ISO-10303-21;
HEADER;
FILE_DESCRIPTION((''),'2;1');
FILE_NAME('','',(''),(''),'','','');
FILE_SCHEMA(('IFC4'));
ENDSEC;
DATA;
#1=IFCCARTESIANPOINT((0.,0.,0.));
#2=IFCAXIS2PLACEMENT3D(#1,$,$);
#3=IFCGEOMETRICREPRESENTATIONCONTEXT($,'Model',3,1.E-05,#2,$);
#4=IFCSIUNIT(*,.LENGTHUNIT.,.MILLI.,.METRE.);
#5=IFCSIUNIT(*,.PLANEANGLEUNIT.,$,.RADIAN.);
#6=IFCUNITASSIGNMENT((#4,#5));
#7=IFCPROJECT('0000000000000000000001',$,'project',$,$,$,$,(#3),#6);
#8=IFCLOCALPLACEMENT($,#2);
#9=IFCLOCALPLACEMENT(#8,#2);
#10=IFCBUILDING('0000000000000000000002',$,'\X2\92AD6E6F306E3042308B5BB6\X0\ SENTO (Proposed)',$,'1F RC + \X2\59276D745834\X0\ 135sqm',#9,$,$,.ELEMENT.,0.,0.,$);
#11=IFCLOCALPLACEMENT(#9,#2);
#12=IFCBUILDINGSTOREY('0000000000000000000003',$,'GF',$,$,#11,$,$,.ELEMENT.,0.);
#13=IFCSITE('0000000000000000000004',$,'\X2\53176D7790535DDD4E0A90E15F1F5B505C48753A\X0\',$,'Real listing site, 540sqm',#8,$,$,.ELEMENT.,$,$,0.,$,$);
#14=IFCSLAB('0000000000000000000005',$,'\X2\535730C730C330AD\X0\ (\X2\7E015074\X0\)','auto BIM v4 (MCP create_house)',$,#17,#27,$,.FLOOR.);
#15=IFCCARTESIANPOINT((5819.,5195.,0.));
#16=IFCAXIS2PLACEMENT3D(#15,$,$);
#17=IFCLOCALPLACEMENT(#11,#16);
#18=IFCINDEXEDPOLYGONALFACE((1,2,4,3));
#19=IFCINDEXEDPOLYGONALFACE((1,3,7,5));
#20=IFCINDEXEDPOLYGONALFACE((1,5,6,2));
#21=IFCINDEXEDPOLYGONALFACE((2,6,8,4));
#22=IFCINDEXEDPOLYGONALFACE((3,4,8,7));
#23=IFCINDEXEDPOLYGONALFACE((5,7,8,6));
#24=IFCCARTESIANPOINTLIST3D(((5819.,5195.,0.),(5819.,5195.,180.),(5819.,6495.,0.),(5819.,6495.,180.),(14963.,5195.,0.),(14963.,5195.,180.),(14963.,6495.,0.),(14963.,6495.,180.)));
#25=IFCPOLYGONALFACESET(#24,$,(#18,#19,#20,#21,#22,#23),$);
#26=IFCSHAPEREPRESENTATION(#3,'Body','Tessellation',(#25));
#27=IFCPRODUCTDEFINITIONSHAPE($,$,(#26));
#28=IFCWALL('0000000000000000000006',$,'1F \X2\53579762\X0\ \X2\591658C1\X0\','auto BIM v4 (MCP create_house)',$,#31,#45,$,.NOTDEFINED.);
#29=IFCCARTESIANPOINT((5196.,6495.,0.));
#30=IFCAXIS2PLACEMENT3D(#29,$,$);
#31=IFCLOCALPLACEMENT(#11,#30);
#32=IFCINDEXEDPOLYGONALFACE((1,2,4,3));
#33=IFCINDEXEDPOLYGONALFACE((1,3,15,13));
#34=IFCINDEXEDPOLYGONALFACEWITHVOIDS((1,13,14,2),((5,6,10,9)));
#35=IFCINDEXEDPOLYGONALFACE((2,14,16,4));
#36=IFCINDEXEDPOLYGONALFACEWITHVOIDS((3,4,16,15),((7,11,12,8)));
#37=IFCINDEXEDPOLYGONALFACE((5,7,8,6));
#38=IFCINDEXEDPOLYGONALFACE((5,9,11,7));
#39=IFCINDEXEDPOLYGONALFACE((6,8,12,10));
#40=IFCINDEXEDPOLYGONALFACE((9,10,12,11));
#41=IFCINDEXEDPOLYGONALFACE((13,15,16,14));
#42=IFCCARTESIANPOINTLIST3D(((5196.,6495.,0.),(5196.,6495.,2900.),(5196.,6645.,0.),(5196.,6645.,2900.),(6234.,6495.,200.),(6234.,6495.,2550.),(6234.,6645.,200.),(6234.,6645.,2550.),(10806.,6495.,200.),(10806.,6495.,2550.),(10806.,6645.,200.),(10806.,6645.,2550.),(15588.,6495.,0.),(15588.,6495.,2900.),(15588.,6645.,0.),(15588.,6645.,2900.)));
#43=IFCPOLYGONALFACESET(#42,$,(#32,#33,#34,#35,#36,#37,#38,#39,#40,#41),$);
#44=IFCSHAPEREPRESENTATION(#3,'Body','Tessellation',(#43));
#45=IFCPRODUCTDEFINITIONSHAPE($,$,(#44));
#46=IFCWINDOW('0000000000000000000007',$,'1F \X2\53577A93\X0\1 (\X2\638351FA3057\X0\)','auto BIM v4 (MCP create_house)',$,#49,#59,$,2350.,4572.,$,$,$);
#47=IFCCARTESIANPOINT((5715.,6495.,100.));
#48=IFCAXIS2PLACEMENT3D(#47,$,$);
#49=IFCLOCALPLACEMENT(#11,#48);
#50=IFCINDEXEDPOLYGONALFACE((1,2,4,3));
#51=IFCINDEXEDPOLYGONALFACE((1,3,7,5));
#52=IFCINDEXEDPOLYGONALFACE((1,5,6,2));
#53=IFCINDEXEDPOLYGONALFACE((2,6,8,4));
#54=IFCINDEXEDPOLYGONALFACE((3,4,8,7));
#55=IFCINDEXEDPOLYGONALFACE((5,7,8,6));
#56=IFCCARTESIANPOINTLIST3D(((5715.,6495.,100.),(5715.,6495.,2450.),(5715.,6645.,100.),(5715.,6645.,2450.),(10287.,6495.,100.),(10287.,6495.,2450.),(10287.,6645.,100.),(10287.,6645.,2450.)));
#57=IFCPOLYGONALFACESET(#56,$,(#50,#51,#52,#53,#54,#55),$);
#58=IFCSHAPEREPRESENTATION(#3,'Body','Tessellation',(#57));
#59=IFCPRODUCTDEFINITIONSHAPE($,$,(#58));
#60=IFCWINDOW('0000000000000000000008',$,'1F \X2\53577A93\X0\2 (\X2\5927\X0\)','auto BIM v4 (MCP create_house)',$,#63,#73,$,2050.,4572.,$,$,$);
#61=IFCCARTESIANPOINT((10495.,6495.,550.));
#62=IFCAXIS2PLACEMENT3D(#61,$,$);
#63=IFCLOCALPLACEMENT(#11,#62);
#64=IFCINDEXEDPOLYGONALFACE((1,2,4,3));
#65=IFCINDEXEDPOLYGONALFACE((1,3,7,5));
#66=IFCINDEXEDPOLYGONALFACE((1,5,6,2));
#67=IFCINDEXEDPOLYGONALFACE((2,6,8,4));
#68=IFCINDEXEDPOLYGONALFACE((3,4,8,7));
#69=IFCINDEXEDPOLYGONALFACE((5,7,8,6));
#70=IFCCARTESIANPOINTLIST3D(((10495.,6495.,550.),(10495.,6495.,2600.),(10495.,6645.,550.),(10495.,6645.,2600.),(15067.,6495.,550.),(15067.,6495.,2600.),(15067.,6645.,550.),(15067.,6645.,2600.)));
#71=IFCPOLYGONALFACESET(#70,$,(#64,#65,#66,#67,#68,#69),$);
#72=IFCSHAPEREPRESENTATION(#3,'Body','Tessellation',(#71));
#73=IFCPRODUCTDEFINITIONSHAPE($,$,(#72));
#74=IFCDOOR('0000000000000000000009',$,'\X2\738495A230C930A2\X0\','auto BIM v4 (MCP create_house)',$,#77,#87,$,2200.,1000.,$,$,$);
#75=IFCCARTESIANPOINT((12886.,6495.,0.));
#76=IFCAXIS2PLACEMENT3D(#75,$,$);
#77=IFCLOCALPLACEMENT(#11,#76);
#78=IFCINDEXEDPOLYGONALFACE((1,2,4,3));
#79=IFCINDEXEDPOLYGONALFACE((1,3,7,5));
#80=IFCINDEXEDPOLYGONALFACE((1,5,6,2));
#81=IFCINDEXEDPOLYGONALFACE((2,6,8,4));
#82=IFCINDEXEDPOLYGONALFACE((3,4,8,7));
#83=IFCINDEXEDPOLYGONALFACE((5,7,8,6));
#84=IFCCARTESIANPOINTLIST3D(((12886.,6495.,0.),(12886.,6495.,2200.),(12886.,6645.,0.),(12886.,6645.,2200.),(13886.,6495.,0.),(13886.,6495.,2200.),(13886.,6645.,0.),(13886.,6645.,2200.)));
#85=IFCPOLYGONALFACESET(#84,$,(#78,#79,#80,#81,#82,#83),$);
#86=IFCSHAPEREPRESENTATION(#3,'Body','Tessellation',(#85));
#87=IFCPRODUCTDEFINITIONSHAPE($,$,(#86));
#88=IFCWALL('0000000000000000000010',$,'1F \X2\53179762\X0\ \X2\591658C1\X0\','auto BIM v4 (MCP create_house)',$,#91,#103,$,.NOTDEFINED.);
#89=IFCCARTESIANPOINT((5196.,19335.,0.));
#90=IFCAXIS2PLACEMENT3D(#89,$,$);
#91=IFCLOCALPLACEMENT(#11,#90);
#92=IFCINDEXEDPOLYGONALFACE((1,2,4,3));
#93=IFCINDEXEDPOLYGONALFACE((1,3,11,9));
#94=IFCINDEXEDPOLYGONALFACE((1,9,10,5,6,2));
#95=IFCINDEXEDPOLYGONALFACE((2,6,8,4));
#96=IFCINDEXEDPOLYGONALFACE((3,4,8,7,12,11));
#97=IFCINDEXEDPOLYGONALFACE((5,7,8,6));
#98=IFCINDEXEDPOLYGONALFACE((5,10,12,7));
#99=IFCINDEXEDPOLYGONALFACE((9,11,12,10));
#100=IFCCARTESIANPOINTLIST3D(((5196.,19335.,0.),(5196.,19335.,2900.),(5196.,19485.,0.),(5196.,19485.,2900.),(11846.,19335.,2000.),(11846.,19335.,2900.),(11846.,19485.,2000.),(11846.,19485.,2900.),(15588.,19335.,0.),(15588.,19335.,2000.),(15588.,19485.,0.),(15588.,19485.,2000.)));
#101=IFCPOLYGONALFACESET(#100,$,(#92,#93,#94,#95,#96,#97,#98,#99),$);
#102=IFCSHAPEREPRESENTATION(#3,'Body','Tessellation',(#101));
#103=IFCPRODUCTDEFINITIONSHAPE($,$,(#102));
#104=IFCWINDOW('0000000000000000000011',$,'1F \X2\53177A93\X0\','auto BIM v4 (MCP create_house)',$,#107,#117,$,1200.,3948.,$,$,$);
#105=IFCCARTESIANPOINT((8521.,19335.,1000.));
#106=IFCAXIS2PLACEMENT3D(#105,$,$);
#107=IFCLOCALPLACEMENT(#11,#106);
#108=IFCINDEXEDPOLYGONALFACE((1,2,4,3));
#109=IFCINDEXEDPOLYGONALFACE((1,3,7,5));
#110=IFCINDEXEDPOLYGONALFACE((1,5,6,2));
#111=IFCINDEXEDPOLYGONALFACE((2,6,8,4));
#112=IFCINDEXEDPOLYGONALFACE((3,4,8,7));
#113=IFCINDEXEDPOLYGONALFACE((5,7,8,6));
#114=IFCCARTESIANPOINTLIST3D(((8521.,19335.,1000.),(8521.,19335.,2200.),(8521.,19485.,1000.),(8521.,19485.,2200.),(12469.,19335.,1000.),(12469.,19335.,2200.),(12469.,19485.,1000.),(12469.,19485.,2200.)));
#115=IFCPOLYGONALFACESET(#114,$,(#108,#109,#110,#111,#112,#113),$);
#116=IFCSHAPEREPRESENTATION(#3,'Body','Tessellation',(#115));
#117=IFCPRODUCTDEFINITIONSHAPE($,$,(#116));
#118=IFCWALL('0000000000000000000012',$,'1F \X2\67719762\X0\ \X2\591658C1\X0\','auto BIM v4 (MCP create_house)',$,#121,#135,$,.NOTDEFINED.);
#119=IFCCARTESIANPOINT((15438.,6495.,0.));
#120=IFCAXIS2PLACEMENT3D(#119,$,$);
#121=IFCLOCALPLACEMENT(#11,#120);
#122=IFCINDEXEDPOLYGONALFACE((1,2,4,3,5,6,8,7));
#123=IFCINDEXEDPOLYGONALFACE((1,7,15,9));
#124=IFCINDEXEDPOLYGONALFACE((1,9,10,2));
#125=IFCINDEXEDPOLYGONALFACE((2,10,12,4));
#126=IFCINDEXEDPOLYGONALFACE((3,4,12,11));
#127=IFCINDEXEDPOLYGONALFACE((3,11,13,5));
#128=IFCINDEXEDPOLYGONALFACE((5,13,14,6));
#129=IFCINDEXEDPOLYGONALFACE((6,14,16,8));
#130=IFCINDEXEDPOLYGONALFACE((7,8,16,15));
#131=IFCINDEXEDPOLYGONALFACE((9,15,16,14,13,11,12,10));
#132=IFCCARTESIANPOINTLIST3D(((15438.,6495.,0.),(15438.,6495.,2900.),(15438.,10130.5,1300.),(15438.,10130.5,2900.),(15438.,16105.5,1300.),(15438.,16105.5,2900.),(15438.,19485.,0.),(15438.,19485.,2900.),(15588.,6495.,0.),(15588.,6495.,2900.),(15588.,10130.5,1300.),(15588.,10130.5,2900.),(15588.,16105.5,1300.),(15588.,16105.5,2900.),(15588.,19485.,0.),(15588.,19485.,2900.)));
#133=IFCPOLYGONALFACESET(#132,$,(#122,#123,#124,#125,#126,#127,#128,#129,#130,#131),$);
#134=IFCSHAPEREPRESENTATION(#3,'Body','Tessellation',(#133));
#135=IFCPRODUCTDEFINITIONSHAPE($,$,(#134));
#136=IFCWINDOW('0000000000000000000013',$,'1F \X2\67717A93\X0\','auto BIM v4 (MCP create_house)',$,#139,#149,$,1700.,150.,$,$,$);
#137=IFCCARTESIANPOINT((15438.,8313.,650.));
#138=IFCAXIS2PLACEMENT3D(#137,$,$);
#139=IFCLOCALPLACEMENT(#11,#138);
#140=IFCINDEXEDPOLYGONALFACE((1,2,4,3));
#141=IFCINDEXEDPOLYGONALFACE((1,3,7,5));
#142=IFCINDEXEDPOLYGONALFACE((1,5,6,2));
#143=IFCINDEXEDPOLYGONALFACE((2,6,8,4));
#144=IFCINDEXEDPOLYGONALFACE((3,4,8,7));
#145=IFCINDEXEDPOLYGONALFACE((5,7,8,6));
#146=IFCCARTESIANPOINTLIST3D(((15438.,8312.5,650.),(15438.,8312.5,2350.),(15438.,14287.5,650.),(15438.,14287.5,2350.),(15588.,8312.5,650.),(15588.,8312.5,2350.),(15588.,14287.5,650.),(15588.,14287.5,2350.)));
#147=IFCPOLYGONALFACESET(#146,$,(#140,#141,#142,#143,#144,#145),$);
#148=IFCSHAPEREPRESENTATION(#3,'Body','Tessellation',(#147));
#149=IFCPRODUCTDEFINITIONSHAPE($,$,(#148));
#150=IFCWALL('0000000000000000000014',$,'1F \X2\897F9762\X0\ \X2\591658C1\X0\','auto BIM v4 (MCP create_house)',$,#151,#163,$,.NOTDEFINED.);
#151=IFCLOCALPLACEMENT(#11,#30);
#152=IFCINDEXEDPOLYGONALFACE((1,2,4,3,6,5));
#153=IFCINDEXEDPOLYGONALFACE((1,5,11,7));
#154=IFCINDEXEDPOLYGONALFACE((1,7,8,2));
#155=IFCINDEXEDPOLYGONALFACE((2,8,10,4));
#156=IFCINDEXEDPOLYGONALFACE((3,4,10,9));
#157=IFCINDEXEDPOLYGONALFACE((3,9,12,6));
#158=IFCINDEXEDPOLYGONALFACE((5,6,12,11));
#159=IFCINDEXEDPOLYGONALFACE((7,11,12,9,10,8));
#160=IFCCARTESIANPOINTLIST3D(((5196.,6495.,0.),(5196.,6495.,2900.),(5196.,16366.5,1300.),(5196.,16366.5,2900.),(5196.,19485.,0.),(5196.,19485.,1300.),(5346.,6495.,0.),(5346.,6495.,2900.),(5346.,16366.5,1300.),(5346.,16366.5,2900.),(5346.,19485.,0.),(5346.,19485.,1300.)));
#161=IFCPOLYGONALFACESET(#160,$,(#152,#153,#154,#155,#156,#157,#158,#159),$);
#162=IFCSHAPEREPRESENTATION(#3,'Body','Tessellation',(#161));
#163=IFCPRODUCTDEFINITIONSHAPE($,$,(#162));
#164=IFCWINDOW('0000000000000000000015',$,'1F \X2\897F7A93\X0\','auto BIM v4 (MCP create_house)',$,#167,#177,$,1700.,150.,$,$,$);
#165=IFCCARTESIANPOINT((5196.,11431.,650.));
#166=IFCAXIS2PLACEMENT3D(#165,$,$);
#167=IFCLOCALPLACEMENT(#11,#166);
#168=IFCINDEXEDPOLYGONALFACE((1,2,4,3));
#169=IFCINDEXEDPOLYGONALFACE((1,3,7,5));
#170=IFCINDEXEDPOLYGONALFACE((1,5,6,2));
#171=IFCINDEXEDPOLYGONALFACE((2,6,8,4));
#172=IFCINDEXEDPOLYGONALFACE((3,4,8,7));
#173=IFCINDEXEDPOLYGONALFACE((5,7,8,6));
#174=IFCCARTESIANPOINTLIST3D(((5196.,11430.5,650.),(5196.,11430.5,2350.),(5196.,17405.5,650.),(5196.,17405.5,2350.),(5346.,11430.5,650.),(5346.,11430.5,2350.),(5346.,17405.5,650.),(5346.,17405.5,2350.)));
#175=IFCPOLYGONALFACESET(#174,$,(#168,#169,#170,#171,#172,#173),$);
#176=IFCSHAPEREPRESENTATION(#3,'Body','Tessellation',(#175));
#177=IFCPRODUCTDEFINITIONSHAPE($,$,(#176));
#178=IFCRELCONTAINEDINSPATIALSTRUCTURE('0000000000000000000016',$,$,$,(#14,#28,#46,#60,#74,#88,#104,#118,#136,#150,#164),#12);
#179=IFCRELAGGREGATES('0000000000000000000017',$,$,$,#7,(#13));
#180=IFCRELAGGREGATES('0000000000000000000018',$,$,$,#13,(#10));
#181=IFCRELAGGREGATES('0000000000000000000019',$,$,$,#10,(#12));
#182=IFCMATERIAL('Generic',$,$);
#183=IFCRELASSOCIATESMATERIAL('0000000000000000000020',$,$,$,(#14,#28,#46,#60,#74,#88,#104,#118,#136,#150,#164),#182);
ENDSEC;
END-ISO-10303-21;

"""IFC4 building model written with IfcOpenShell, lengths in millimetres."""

from ifc_helpers import new_model, si_unit, frame, frame_2d, origin, place, context, project, spatial, rectangle, extrude, material, element, fill, save


model = new_model("IFC4")

# Units and contexts
model_context = context("Model", 3, precision=1e-05, world=origin())
ifc_project = project(units=[si_unit("LENGTHUNIT", "METRE", prefix="MILLI"), si_unit("PLANEANGLEUNIT", "RADIAN")], contexts=[model_context])

# Site, building, storey
site_placement = place(None, origin())
site = spatial("IfcSite", under=ifc_project, at=site_placement, Name="北海道川上郡弟子屈町", ObjectType="Real listing site, 540sqm", CompositionType="ELEMENT", RefElevation=0.0)
building_placement = place(site_placement, origin())
building = spatial("IfcBuilding", under=site, at=building_placement, Name="銭湯のある家 SENTO (Proposed)", ObjectType="1F RC + 大浴場 135sqm", CompositionType="ELEMENT", ElevationOfRefHeight=0.0, ElevationOfTerrain=0.0)
storey_placement = place(building_placement, origin())
storey = spatial("IfcBuildingStorey", under=building, at=storey_placement, Name="GF", CompositionType="ELEMENT", Elevation=0.0)

# Slab
ifc_material = material(Name="Generic")
slab_1_placement = place(storey_placement, frame((5819.0, 5195.0, 0.0)))
element("IfcSlab", 1, at=slab_1_placement, inside=storey, material=ifc_material, Name="南デッキ (縁側)", Description="auto BIM v4 (MCP create_house)", PredefinedType="FLOOR", context=model_context, shape_type="SweptSolid", body=[
    extrude(rectangle(XDim=9144.0, YDim=1300.0, at=frame_2d((4572.0, 650.0))), frame((5819.0, 5195.0, 0.0)), (0.0, 0.0, 1.0), 180.0),
])

# Wall, openings, windows, door
wall_1_placement = place(storey_placement, frame((5196.0, 6495.0, 0.0)))
wall_1 = element("IfcWall", 2, at=wall_1_placement, inside=storey, material=ifc_material, Name="1F 南面 外壁", Description="auto BIM v4 (MCP create_house)", PredefinedType="NOTDEFINED", context=model_context, shape_type="SweptSolid", body=[
    extrude(rectangle(XDim=10392.0, YDim=150.0, at=frame_2d((5196.0, 75.0))), frame((5196.0, 6495.0, 0.0)), (0.0, 0.0, 1.0), 2900.0),
])
opening_1_placement = place(storey_placement, frame((5715.0, 6495.0, 100.0)))
opening_1 = element("IfcOpeningElement", 3, at=opening_1_placement, cuts=wall_1, PredefinedType="NOTDEFINED", context=model_context, shape_type="SweptSolid", body=[
    extrude(rectangle(XDim=4572.0, YDim=150.0, at=frame_2d((2286.0, 75.0))), frame((5715.0, 6495.0, 100.0)), (0.0, 0.0, 1.0), 2350.0),
])
opening_2_placement = place(storey_placement, frame((10495.0, 6495.0, 550.0)))
opening_2 = element("IfcOpeningElement", 4, at=opening_2_placement, cuts=wall_1, PredefinedType="NOTDEFINED", context=model_context, shape_type="SweptSolid", body=[
    extrude(rectangle(XDim=4572.0, YDim=150.0, at=frame_2d((2286.0, 75.0))), frame((10495.0, 6495.0, 550.0)), (0.0, 0.0, 1.0), 2050.0),
])
opening_3_placement = place(storey_placement, frame((12886.0, 6495.0, 0.0)))
opening_3 = element("IfcOpeningElement", 5, at=opening_3_placement, cuts=wall_1, PredefinedType="NOTDEFINED", context=model_context, shape_type="SweptSolid", body=[
    extrude(rectangle(XDim=1000.0, YDim=150.0, at=frame_2d((500.0, 75.0))), frame((12886.0, 6495.0, 0.0)), (0.0, 0.0, 1.0), 2200.0),
])
window_1_placement = place(storey_placement, frame((5715.0, 6495.0, 100.0)))
window_1 = element("IfcWindow", 6, at=window_1_placement, inside=storey, material=ifc_material, Name="1F 南窓1 (掃出し)", Description="auto BIM v4 (MCP create_house)", OverallHeight=2350.0, OverallWidth=4572.0, context=model_context, shape_type="SweptSolid", body=[
    extrude(rectangle(XDim=4572.0, YDim=150.0, at=frame_2d((2286.0, 75.0))), frame((5715.0, 6495.0, 100.0)), (0.0, 0.0, 1.0), 2350.0),
])
fill(opening_1, window_1)
window_2_placement = place(storey_placement, frame((10495.0, 6495.0, 550.0)))
window_2 = element("IfcWindow", 7, at=window_2_placement, inside=storey, material=ifc_material, Name="1F 南窓2 (大)", Description="auto BIM v4 (MCP create_house)", OverallHeight=2050.0, OverallWidth=4572.0, context=model_context, shape_type="SweptSolid", body=[
    extrude(rectangle(XDim=4572.0, YDim=150.0, at=frame_2d((2286.0, 75.0))), frame((10495.0, 6495.0, 550.0)), (0.0, 0.0, 1.0), 2050.0),
])
fill(opening_2, window_2)
door_placement = place(storey_placement, frame((12886.0, 6495.0, 0.0)))
door = element("IfcDoor", 8, at=door_placement, inside=storey, material=ifc_material, Name="玄関ドア", Description="auto BIM v4 (MCP create_house)", OverallHeight=2200.0, OverallWidth=1000.0, context=model_context, shape_type="SweptSolid", body=[
    extrude(rectangle(XDim=1000.0, YDim=150.0, at=frame_2d((500.0, 75.0))), frame((12886.0, 6495.0, 0.0)), (0.0, 0.0, 1.0), 2200.0),
])
fill(opening_3, door)

# Walls, openings, windows
wall_2_placement = place(storey_placement, frame((5196.0, 19335.0, 0.0)))
wall_2 = element("IfcWall", 9, at=wall_2_placement, inside=storey, material=ifc_material, Name="1F 北面 外壁", Description="auto BIM v4 (MCP create_house)", PredefinedType="NOTDEFINED", context=model_context, shape_type="SweptSolid", body=[
    extrude(rectangle(XDim=10392.0, YDim=150.0, at=frame_2d((5196.0, 75.0))), frame((5196.0, 19335.0, 0.0)), (0.0, 0.0, 1.0), 2900.0),
])
opening_4_placement = place(storey_placement, frame((8521.0, 19335.0, 1000.0)))
opening_4 = element("IfcOpeningElement", 10, at=opening_4_placement, cuts=wall_2, PredefinedType="NOTDEFINED", context=model_context, shape_type="SweptSolid", body=[
    extrude(rectangle(XDim=3948.0, YDim=150.0, at=frame_2d((1974.0, 75.0))), frame((8521.0, 19335.0, 1000.0)), (0.0, 0.0, 1.0), 1200.0),
])
window_3_placement = place(storey_placement, frame((8521.0, 19335.0, 1000.0)))
window_3 = element("IfcWindow", 11, at=window_3_placement, inside=storey, material=ifc_material, Name="1F 北窓", Description="auto BIM v4 (MCP create_house)", OverallHeight=1200.0, OverallWidth=3948.0, context=model_context, shape_type="SweptSolid", body=[
    extrude(rectangle(XDim=3948.0, YDim=150.0, at=frame_2d((1974.0, 75.0))), frame((8521.0, 19335.0, 1000.0)), (0.0, 0.0, 1.0), 1200.0),
])
fill(opening_4, window_3)
wall_3_placement = place(storey_placement, frame((15438.0, 6495.0, 0.0)))
wall_3 = element("IfcWall", 12, at=wall_3_placement, inside=storey, material=ifc_material, Name="1F 東面 外壁", Description="auto BIM v4 (MCP create_house)", PredefinedType="NOTDEFINED", context=model_context, shape_type="SweptSolid", body=[
    extrude(rectangle(XDim=150.0, YDim=12990.0, at=frame_2d((75.0, 6495.0))), frame((15438.0, 6495.0, 0.0)), (0.0, 0.0, 1.0), 2900.0),
])
opening_5_placement = place(storey_placement, frame((15438.0, 8313.0, 650.0)))
opening_5 = element("IfcOpeningElement", 13, at=opening_5_placement, cuts=wall_3, PredefinedType="NOTDEFINED", context=model_context, shape_type="SweptSolid", body=[
    extrude(rectangle(XDim=150.0, YDim=5975.0, at=frame_2d((75.0, 2987.0))), frame((15438.0, 8313.0, 650.0)), (0.0, 0.0, 1.0), 1700.0),
])
window_4_placement = place(storey_placement, frame((15438.0, 8313.0, 650.0)))
window_4 = element("IfcWindow", 14, at=window_4_placement, inside=storey, material=ifc_material, Name="1F 東窓", Description="auto BIM v4 (MCP create_house)", OverallHeight=1700.0, OverallWidth=150.0, context=model_context, shape_type="SweptSolid", body=[
    extrude(rectangle(XDim=150.0, YDim=5975.0, at=frame_2d((75.0, 2987.0))), frame((15438.0, 8313.0, 650.0)), (0.0, 0.0, 1.0), 1700.0),
])
fill(opening_5, window_4)
wall_4_placement = place(storey_placement, frame((5196.0, 6495.0, 0.0)))
wall_4 = element("IfcWall", 15, at=wall_4_placement, inside=storey, material=ifc_material, Name="1F 西面 外壁", Description="auto BIM v4 (MCP create_house)", PredefinedType="NOTDEFINED", context=model_context, shape_type="SweptSolid", body=[
    extrude(rectangle(XDim=150.0, YDim=12990.0, at=frame_2d((75.0, 6495.0))), frame((5196.0, 6495.0, 0.0)), (0.0, 0.0, 1.0), 2900.0),
])
opening_6_placement = place(storey_placement, frame((5196.0, 11431.0, 650.0)))
opening_6 = element("IfcOpeningElement", 16, at=opening_6_placement, cuts=wall_4, PredefinedType="NOTDEFINED", context=model_context, shape_type="SweptSolid", body=[
    extrude(rectangle(XDim=150.0, YDim=5975.0, at=frame_2d((75.0, 2987.0))), frame((5196.0, 11431.0, 650.0)), (0.0, 0.0, 1.0), 1700.0),
])
window_5_placement = place(storey_placement, frame((5196.0, 11431.0, 650.0)))
window_5 = element("IfcWindow", 17, at=window_5_placement, inside=storey, material=ifc_material, Name="1F 西窓", Description="auto BIM v4 (MCP create_house)", OverallHeight=1700.0, OverallWidth=150.0, context=model_context, shape_type="SweptSolid", body=[
    extrude(rectangle(XDim=150.0, YDim=5975.0, at=frame_2d((75.0, 2987.0))), frame((5196.0, 11431.0, 650.0)), (0.0, 0.0, 1.0), 1700.0),
])
fill(opening_6, window_5)

save(model, "model.ifc")
